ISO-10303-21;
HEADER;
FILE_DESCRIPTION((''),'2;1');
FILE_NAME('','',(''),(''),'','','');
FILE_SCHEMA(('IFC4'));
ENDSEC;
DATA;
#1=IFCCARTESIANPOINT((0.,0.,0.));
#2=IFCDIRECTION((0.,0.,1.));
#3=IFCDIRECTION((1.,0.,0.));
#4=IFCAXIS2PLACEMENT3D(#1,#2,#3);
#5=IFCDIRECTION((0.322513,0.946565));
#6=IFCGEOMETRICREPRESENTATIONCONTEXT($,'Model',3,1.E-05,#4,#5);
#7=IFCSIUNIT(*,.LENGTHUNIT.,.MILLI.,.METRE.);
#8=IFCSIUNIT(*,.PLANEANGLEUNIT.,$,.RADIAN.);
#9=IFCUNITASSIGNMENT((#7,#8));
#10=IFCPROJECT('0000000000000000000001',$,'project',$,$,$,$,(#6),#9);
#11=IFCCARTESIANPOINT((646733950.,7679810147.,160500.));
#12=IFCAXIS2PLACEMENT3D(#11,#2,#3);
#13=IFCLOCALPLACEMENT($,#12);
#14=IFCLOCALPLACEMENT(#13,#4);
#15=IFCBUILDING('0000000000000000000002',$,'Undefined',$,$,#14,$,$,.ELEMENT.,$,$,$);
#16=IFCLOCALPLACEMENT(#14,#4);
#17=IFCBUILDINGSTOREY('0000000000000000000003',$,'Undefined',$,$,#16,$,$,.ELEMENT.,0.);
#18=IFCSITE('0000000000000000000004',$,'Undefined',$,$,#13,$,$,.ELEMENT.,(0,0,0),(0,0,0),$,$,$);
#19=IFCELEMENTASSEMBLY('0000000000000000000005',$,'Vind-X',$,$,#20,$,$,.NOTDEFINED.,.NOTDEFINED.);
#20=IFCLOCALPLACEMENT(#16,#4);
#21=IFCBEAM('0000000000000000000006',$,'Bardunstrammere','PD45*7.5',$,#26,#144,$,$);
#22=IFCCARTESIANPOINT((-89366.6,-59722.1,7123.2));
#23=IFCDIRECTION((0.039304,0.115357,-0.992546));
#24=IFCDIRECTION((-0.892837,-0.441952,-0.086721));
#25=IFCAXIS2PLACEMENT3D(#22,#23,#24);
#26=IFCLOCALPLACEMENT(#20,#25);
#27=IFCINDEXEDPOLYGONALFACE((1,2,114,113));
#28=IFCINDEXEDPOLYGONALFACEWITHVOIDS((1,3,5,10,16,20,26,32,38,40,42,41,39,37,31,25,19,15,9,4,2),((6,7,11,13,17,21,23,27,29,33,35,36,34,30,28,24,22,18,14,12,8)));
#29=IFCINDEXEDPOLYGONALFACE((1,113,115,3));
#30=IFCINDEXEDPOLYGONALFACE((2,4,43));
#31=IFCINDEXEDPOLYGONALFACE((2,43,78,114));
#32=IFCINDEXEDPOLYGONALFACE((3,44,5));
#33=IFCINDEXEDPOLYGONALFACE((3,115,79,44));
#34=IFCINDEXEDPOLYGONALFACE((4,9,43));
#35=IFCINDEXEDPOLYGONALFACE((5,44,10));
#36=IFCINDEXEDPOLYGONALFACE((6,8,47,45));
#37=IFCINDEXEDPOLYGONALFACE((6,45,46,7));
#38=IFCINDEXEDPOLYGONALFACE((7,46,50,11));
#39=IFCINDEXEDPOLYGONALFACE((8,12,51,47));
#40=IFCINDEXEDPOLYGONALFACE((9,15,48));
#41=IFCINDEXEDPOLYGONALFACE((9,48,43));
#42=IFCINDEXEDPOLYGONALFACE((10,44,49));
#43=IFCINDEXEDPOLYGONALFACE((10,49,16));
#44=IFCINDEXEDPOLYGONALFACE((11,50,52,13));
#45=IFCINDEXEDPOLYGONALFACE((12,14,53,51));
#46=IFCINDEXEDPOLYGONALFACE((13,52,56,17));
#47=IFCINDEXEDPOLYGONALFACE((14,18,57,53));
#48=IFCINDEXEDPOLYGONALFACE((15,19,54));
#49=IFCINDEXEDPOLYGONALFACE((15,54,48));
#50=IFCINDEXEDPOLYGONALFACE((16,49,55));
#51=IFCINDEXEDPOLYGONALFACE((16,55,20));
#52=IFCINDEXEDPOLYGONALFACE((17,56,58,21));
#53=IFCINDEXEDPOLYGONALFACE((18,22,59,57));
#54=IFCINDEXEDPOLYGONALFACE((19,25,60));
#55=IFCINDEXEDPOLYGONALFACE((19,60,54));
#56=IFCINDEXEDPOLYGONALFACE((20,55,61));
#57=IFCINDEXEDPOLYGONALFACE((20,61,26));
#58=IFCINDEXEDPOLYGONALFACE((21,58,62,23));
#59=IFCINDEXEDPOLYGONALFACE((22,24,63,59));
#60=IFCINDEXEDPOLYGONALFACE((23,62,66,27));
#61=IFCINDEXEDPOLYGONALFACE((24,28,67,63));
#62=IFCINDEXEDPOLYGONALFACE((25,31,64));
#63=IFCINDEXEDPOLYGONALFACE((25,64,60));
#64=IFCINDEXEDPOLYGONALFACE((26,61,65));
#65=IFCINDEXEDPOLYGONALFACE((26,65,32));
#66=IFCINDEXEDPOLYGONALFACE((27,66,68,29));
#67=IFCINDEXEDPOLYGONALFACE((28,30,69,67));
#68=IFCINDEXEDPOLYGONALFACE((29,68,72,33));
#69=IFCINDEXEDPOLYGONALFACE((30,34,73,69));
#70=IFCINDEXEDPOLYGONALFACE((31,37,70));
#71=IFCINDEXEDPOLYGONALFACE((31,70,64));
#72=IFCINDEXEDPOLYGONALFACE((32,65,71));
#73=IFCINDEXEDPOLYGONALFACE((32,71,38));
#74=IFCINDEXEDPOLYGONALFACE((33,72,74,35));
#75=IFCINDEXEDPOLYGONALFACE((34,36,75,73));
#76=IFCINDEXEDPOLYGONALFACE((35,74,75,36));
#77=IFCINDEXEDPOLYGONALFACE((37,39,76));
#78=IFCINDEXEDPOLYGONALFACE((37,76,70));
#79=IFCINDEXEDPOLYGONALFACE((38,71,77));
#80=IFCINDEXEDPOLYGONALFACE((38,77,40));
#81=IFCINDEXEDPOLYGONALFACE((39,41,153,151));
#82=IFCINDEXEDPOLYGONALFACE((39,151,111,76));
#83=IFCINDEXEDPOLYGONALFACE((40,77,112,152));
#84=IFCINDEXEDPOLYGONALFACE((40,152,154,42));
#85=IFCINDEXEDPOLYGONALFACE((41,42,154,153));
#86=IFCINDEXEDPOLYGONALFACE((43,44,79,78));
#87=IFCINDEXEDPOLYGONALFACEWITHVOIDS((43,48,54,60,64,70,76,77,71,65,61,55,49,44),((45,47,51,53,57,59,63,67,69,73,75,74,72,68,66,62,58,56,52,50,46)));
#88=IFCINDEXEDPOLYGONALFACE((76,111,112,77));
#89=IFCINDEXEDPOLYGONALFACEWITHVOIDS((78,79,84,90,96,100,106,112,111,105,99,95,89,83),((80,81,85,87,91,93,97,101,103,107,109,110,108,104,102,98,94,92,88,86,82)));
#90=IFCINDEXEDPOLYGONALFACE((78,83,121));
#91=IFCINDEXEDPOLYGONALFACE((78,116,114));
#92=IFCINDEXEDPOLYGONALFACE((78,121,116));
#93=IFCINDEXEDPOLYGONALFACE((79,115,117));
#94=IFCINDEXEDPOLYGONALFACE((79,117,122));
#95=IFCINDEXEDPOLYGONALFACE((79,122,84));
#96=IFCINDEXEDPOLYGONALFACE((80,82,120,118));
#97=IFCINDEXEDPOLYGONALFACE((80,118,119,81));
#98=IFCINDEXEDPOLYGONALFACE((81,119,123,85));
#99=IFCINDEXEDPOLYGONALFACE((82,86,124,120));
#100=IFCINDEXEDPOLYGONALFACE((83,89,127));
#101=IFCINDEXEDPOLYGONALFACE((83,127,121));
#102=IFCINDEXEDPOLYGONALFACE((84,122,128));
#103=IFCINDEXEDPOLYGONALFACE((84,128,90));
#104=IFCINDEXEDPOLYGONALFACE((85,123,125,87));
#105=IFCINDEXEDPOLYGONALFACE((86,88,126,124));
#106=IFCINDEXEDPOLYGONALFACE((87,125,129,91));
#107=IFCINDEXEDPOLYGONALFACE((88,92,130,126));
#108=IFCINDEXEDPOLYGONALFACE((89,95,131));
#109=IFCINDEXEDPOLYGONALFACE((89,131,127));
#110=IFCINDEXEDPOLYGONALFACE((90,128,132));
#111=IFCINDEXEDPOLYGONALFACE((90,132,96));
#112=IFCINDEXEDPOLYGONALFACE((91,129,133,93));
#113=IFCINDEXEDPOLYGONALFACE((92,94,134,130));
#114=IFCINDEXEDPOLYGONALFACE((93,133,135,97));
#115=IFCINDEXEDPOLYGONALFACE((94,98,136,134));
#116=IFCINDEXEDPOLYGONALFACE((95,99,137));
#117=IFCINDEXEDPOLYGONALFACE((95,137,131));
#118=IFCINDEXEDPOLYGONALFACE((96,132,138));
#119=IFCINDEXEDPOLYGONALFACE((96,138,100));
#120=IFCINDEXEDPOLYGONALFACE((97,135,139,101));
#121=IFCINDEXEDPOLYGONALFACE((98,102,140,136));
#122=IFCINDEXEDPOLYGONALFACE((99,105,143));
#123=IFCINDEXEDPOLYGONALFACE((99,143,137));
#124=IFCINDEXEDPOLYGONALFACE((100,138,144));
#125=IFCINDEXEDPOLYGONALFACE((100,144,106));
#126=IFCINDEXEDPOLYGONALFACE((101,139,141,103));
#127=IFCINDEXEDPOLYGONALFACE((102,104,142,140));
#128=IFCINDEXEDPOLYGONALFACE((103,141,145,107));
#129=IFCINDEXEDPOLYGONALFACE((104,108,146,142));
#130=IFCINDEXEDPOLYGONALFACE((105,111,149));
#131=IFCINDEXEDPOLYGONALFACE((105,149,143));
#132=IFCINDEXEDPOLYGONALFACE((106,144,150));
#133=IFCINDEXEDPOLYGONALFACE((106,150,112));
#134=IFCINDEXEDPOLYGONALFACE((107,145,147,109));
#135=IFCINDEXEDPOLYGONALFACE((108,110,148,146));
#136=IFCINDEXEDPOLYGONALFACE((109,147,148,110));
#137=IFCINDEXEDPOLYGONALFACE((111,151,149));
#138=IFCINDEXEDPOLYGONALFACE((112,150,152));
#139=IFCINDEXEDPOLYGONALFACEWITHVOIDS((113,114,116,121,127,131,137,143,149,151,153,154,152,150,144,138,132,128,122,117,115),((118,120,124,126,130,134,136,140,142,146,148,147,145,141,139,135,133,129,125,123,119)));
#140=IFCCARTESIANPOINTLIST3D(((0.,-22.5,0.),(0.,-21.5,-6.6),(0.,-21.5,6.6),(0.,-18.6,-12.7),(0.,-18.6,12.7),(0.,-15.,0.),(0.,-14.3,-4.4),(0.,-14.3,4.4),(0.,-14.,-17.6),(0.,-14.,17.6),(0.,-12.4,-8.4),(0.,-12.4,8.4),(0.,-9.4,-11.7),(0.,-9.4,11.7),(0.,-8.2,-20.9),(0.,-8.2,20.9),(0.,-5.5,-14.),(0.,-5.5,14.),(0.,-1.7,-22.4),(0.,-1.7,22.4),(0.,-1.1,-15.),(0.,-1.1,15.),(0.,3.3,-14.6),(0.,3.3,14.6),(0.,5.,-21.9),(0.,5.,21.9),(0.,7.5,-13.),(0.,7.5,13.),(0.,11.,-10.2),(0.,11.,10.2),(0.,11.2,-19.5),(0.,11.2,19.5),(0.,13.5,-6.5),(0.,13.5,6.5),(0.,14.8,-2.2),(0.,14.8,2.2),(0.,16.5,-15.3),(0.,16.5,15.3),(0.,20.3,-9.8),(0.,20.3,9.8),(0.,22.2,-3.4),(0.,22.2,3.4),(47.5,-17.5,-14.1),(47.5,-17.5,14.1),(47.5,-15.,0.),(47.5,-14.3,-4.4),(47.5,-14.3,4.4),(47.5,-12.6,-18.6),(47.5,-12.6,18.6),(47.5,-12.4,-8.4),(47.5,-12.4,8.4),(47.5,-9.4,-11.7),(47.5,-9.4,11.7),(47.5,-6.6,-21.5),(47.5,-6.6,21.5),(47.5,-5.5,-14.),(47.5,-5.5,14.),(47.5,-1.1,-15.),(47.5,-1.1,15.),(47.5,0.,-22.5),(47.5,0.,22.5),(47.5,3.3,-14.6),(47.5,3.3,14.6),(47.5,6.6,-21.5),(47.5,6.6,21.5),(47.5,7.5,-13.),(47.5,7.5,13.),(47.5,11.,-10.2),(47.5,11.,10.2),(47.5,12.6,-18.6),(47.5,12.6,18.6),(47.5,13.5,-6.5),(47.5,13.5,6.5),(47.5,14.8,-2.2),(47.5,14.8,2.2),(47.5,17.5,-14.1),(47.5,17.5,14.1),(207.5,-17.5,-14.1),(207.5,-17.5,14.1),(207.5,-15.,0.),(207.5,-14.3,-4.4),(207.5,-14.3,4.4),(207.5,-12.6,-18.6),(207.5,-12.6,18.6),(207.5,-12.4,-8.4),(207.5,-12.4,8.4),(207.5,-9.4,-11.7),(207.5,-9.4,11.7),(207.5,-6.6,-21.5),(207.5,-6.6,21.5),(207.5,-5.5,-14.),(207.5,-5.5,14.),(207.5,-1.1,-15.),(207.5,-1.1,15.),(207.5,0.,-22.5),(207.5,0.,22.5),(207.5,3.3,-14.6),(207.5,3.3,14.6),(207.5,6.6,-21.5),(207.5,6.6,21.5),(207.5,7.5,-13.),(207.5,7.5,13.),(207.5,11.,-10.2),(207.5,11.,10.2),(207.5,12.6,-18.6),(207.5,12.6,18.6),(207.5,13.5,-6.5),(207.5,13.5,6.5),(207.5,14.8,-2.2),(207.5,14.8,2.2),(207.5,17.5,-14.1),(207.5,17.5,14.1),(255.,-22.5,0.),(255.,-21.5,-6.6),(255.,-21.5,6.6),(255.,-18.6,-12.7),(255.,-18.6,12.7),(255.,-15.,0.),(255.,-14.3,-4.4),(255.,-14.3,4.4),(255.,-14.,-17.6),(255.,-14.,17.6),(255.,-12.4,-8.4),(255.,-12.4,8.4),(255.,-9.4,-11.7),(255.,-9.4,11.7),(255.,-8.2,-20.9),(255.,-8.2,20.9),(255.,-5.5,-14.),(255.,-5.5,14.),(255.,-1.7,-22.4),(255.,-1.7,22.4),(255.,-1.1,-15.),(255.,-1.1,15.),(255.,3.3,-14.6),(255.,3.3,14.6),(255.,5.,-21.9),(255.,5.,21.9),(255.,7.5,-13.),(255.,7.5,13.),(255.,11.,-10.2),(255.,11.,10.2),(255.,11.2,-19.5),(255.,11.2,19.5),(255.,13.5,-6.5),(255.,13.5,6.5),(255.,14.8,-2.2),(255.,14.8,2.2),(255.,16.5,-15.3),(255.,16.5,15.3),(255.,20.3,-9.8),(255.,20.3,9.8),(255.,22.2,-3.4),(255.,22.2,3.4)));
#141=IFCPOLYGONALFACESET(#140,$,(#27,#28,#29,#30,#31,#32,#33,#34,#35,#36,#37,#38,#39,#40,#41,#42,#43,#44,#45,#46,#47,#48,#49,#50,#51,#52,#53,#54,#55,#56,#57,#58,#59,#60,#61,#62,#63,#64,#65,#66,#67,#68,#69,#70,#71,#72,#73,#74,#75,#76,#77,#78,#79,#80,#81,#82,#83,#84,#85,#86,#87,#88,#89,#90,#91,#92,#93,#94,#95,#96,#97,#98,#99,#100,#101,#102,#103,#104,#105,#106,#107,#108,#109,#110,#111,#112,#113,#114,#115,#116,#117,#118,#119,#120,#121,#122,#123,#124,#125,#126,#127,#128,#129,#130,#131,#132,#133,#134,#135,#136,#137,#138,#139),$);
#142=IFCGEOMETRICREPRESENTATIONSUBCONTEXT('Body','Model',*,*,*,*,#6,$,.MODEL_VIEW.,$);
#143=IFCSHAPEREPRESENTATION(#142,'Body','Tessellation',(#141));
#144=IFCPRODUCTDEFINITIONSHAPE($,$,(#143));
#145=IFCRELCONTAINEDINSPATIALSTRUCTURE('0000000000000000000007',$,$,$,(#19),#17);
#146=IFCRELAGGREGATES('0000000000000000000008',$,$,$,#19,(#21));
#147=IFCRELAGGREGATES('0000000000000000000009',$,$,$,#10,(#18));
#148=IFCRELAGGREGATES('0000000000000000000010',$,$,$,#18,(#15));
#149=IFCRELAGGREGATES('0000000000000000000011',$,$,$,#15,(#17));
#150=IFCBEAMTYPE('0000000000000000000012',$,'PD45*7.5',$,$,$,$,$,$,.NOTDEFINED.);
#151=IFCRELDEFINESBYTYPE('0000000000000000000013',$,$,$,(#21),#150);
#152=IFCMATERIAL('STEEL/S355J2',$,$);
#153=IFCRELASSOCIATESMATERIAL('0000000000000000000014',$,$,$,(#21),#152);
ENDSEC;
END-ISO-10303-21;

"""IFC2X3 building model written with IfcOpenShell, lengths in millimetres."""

from ifc_helpers import new_model, si_unit, direction, frame, origin_with_axes, origin_2d_with_axis, place, context, subcontext, project, spatial, rectangle, hollow_circle, extrude, boolean, material, type_object, element, aggregate, save


model = new_model("IFC2X3")

# Units and contexts
model_context = context("Model", 3, precision=1e-05, world=origin_with_axes(), true_north=direction((0.322513, 0.946565)))
body_context = subcontext(model_context, "Body", "Model", "MODEL_VIEW")
ifc_project = project(units=[si_unit("LENGTHUNIT", "METRE", prefix="MILLI"), si_unit("PLANEANGLEUNIT", "RADIAN")], contexts=[model_context])

# Site, building, storey
site_placement = place(None, frame((646733950.0, 7679810147.0, 160500.0), z_axis=(0.0, 0.0, 1.0), x_axis=(1.0, 0.0, 0.0)))
site = spatial("IfcSite", under=ifc_project, at=site_placement, Name="Undefined", CompositionType="ELEMENT", RefLatitude=(0, 0, 0), RefLongitude=(0, 0, 0))
building_placement = place(site_placement, origin_with_axes())
building = spatial("IfcBuilding", under=site, at=building_placement, Name="Undefined", CompositionType="ELEMENT")
storey_placement = place(building_placement, origin_with_axes())
storey = spatial("IfcBuildingStorey", under=building, at=storey_placement, Name="Undefined", CompositionType="ELEMENT", Elevation=0.0)

# Element assembly, beam
assembly_1_placement = place(storey_placement, origin_with_axes())
assembly_1 = element("IfcElementAssembly", 1, at=assembly_1_placement, inside=storey, Name="Vind-X", AssemblyPlace="NOTDEFINED", PredefinedType="NOTDEFINED")
ifc_material_1 = material(Name="STEEL/S355J2")
beam_type_1 = type_object("IfcBeamType", Name="PD45*7.5", PredefinedType="NOTDEFINED")
beam_1_placement = place(assembly_1_placement, frame((-89366.6, -59722.1, 7123.2), z_axis=(0.039304, 0.115357, -0.992546), x_axis=(-0.892837, -0.441952, -0.086721)))
beam_1 = element("IfcBeam", 2, at=beam_1_placement, type_object=beam_type_1, material=ifc_material_1, Name="Bardunstrammere", Description="PD45*7.5", context=body_context, shape_type="CSG", body=[
    boolean("DIFFERENCE", extrude(hollow_circle(Radius=22.5, WallThickness=7.5, at=origin_2d_with_axis()), frame((255.0, 0.0, 0.0), z_axis=(-1.0, 0.0, 0.0), x_axis=(0.0, -1.0, 0.0)), (0.0, 0.0, 1.0), 255.0), extrude(rectangle(XDim=35.0, YDim=90.0, at=origin_2d_with_axis()), frame((207.5, 0.0, 0.0), z_axis=(-1.0, 0.0, 0.0), x_axis=(0.0, -1.0, 0.0)), (0.0, 0.0, 1.0), 160.0)),
])

aggregate(assembly_1, [beam_1])

save(model, "model.ifc")
